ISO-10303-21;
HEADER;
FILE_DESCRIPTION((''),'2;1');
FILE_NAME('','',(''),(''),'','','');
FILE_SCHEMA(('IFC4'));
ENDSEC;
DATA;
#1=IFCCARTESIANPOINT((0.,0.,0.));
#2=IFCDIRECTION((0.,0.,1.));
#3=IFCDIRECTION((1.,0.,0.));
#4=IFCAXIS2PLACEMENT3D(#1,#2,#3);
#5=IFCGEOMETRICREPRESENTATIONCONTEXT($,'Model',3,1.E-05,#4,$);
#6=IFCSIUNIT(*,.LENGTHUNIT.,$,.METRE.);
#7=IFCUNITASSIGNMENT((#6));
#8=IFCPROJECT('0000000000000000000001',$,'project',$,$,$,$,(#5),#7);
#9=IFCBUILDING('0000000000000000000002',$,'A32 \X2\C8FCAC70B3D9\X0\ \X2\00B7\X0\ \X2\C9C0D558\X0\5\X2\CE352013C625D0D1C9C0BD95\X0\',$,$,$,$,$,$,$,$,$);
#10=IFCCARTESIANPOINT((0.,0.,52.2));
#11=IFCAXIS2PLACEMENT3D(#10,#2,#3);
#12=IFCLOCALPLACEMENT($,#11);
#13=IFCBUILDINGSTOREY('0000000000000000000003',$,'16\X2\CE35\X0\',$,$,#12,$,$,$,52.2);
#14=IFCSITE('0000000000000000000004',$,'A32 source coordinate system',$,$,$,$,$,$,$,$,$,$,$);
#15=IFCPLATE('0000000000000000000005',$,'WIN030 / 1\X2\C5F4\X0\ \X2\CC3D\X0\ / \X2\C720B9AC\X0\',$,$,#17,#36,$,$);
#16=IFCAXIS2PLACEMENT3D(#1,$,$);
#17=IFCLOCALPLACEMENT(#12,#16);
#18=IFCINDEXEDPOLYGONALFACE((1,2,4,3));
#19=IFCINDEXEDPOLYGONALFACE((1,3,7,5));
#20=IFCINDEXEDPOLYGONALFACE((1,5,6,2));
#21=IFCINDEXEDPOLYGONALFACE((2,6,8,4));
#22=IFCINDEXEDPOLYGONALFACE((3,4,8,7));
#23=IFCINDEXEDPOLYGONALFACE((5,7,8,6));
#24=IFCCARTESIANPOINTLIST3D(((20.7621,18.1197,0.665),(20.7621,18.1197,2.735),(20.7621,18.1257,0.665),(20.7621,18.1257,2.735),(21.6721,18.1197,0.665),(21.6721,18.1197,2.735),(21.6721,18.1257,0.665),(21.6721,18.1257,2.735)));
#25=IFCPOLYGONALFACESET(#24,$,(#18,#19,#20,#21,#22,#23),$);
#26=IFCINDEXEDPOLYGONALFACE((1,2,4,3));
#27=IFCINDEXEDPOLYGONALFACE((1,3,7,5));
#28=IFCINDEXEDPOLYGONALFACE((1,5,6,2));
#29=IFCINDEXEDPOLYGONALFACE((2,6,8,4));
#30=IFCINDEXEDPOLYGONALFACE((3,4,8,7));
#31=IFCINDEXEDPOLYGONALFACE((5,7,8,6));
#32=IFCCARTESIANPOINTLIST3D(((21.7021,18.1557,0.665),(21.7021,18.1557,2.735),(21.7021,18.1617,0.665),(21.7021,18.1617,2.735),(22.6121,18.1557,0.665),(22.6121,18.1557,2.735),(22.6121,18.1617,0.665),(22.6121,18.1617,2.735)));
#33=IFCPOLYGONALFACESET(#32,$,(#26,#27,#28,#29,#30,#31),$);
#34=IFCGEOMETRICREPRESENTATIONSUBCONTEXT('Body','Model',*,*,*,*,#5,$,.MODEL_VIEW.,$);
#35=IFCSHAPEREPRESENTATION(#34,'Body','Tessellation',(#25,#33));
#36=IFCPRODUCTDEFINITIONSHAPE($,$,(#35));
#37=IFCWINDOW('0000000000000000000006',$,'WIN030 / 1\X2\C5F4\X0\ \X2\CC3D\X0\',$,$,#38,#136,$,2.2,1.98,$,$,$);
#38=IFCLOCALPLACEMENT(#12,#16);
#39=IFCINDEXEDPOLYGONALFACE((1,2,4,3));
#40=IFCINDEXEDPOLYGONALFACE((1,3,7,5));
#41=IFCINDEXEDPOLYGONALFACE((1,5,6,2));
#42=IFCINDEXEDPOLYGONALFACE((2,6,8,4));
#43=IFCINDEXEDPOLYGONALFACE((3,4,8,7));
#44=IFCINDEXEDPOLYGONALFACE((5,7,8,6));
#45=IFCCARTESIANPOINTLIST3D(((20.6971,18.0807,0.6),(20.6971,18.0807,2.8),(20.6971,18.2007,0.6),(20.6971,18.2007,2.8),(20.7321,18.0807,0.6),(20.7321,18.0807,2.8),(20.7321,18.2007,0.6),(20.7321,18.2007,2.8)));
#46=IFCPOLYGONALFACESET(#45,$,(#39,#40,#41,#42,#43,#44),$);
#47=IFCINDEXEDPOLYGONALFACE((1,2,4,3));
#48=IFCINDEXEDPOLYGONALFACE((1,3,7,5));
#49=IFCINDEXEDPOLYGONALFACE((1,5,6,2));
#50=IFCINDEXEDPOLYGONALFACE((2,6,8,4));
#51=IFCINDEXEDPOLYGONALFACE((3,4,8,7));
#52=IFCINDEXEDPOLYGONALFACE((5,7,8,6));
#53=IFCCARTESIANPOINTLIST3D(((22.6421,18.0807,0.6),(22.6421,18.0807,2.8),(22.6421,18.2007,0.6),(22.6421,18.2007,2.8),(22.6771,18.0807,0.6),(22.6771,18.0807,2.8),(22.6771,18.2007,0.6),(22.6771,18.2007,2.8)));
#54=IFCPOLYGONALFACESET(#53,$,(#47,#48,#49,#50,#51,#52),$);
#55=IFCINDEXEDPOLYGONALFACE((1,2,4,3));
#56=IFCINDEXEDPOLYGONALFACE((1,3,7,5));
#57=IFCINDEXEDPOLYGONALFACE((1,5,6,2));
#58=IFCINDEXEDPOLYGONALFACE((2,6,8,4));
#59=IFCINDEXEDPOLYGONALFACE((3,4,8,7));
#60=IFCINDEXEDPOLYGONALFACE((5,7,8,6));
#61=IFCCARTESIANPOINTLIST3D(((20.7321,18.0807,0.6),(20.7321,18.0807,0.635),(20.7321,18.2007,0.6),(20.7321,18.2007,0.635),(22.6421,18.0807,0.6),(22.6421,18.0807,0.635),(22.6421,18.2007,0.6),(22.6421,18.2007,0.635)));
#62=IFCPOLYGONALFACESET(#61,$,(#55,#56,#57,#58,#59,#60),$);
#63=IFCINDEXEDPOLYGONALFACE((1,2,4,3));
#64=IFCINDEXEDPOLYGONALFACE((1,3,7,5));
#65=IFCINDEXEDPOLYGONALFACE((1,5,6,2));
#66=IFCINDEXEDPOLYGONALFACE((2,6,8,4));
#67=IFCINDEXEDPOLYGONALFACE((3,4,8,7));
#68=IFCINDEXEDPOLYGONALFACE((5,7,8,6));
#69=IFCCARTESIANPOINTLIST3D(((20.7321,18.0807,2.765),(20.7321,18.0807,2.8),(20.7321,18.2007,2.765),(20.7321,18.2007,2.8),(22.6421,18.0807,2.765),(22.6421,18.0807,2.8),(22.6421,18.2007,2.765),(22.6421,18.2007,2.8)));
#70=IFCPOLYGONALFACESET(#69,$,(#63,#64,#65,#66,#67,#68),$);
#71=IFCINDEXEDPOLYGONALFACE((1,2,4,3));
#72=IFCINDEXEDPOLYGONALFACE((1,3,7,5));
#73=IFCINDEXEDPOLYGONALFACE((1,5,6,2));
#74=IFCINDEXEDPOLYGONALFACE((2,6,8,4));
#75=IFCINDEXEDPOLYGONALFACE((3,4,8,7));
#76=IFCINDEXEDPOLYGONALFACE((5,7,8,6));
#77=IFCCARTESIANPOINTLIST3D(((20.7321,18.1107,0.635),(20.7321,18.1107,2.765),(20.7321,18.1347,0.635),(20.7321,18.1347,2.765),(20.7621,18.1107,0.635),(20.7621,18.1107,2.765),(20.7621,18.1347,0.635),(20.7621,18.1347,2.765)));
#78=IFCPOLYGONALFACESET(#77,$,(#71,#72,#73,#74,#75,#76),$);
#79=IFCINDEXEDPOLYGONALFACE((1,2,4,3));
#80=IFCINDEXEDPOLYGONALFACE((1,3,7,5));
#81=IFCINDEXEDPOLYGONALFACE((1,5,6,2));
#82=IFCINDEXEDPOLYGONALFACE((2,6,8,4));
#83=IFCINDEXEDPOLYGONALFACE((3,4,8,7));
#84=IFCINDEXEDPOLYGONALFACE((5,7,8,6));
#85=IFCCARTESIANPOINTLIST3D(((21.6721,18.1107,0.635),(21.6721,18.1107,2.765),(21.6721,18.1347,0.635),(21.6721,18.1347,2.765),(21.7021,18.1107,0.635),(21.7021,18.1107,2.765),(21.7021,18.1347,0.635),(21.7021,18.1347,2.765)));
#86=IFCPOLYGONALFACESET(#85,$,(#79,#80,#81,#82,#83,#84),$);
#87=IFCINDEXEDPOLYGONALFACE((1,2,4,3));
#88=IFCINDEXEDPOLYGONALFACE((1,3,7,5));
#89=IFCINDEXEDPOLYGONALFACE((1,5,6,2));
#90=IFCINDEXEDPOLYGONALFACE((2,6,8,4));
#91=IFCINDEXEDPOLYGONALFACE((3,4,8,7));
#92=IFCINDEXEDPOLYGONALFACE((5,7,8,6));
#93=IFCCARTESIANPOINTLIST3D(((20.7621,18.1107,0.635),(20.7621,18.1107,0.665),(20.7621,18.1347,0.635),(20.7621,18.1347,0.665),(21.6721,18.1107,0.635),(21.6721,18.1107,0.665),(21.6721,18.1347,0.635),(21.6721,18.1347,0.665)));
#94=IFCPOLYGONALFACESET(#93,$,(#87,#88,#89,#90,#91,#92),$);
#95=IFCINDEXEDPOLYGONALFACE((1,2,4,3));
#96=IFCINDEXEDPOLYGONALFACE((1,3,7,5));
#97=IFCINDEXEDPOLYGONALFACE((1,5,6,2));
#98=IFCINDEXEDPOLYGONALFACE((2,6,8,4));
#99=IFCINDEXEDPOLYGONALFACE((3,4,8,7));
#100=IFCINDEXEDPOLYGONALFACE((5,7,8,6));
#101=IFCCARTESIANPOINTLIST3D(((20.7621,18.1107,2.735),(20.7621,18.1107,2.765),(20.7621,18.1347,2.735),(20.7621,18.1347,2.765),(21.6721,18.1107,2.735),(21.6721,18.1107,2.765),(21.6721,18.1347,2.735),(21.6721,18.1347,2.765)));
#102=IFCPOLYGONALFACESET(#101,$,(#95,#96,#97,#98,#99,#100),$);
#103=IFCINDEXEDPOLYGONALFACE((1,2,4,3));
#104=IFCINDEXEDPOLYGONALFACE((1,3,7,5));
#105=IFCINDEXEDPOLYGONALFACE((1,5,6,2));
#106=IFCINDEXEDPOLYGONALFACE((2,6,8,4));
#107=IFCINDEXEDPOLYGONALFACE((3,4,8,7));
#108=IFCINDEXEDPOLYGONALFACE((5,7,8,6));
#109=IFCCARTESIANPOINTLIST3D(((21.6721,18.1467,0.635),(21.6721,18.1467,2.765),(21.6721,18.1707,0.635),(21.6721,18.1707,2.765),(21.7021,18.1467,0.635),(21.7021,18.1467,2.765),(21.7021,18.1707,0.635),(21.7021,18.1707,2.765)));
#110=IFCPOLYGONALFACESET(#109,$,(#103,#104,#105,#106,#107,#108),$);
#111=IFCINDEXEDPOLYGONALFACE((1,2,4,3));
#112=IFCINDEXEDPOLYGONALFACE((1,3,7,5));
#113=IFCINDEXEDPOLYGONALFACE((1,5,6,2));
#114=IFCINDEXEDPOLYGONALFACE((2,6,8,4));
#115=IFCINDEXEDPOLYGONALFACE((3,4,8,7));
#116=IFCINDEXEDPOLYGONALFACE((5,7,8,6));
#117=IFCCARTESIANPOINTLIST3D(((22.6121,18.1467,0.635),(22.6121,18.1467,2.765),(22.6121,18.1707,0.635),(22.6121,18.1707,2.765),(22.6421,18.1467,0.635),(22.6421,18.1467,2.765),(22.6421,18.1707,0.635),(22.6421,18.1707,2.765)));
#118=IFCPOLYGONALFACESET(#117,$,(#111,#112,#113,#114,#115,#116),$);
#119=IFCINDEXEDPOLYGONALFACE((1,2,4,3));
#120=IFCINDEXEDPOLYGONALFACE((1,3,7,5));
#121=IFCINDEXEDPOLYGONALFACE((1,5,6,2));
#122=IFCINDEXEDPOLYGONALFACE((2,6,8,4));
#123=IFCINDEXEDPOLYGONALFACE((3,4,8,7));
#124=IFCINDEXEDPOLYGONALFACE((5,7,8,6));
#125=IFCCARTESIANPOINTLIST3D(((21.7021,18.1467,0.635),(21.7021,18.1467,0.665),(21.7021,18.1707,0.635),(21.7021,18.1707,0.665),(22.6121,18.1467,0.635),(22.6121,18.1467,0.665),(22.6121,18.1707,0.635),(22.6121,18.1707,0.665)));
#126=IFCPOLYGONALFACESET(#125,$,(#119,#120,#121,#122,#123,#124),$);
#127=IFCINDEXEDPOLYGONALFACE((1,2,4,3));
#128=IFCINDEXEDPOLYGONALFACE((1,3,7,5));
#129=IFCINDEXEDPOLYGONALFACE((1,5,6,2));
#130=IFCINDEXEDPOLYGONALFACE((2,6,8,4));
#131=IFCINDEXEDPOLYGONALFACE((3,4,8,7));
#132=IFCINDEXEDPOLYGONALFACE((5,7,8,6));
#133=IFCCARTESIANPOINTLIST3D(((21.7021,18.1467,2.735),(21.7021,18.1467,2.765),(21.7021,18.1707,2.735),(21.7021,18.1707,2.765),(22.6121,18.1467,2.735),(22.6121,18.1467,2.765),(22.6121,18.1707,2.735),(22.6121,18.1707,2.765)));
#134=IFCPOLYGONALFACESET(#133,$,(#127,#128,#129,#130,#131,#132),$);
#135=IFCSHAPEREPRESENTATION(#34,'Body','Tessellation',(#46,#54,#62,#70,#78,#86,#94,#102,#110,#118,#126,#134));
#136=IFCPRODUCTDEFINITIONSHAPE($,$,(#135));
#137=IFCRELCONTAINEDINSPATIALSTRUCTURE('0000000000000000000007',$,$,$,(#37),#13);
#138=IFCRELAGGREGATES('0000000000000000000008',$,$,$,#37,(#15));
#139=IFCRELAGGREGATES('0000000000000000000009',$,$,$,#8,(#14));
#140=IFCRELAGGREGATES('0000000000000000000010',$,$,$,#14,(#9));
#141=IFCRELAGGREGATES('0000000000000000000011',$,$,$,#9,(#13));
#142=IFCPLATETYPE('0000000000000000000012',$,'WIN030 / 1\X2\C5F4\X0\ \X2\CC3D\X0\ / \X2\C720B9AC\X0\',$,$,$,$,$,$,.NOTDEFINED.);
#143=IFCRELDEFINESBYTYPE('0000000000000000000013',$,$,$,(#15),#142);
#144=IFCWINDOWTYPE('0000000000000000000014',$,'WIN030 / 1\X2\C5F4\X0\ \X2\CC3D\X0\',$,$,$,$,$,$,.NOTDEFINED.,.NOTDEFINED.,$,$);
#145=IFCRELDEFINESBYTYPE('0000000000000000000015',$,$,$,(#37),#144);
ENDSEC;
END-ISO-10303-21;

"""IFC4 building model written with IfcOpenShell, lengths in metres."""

from ifc_helpers import new_model, si_unit, frame, origin, origin_with_axes, place, context, subcontext, project, spatial, polyline, outline, extrude, source, transform, mapped, type_object, type_shapes, element, aggregate, save


model = new_model("IFC4")

# Units and contexts
model_context = context("Model", 3, precision=1e-05, world=origin_with_axes())
body_context = subcontext(model_context, "Body", "Model", "MODEL_VIEW")
ifc_project = project(units=[si_unit("LENGTHUNIT", "METRE")], contexts=[model_context])

# Plate
storey_placement = place(None, frame((0.0, 0.0, 52.2), z_axis=(0.0, 0.0, 1.0), x_axis=(1.0, 0.0, 0.0)))
plate_type_1 = type_object("IfcPlateType", Name="WIN030 / 1열 창 / 유리", PredefinedType="NOTDEFINED")
shared_shape_1 = source(origin(), body_context, "Body", "SweptSolid", [
    extrude(outline(polyline([(20.7621, 18.1197), (20.7621, 18.1257), (21.6721, 18.1257), (21.6721, 18.1197), (20.7621, 18.1197)])), frame((0.0, 0.0, 0.665)), (0.0, 0.0, 1.0), 2.07),
    extrude(outline(polyline([(21.7021, 18.1557), (21.7021, 18.1617), (22.6121, 18.1617), (22.6121, 18.1557), (21.7021, 18.1557)])), frame((0.0, 0.0, 0.665)), (0.0, 0.0, 1.0), 2.07),
])
type_shapes(plate_type_1, [shared_shape_1])
window_1_placement = place(storey_placement, origin_with_axes())
plate_1_placement = place(window_1_placement, origin_with_axes())
plate_1 = element("IfcPlate", 1, at=plate_1_placement, type_object=plate_type_1, Name="WIN030 / 1열 창 / 유리", context=body_context, shape_type="MappedRepresentation", body=[
    mapped(shared_shape_1, transform((0.0, 0.0, 0.0), scale=1.0)),
])

# Site, building, storey
site = spatial("IfcSite", under=ifc_project, Name="A32 source coordinate system")
building = spatial("IfcBuilding", under=site, Name="A32 주거동 · 지하5층–옥탑지붕")
storey = spatial("IfcBuildingStorey", under=building, at=storey_placement, Name="16층", Elevation=52.2)

# Window
window_type_1 = type_object("IfcWindowType", Name="WIN030 / 1열 창", PartitioningType="NOTDEFINED", PredefinedType="NOTDEFINED")
shared_shape_2 = source(origin(), body_context, "Body", "SweptSolid", [
    extrude(outline(polyline([(20.6971, 18.0807), (20.6971, 18.2007), (20.7321, 18.2007), (20.7321, 18.0807), (20.6971, 18.0807)])), frame((0.0, 0.0, 0.6)), (0.0, 0.0, 1.0), 2.2),
    extrude(outline(polyline([(22.6421, 18.0807), (22.6421, 18.2007), (22.6771, 18.2007), (22.6771, 18.0807), (22.6421, 18.0807)])), frame((0.0, 0.0, 0.6)), (0.0, 0.0, 1.0), 2.2),
    extrude(outline(polyline([(20.7321, 18.0807), (20.7321, 18.2007), (22.6421, 18.2007), (22.6421, 18.0807), (20.7321, 18.0807)])), frame((0.0, 0.0, 0.6)), (0.0, 0.0, 1.0), 0.035),
    extrude(outline(polyline([(20.7321, 18.0807), (20.7321, 18.2007), (22.6421, 18.2007), (22.6421, 18.0807), (20.7321, 18.0807)])), frame((0.0, 0.0, 2.765)), (0.0, 0.0, 1.0), 0.035),
    extrude(outline(polyline([(20.7321, 18.1107), (20.7321, 18.1347), (20.7621, 18.1347), (20.7621, 18.1107), (20.7321, 18.1107)])), frame((0.0, 0.0, 0.635)), (0.0, 0.0, 1.0), 2.13),
    extrude(outline(polyline([(21.6721, 18.1107), (21.6721, 18.1347), (21.7021, 18.1347), (21.7021, 18.1107), (21.6721, 18.1107)])), frame((0.0, 0.0, 0.635)), (0.0, 0.0, 1.0), 2.13),
    extrude(outline(polyline([(20.7621, 18.1107), (20.7621, 18.1347), (21.6721, 18.1347), (21.6721, 18.1107), (20.7621, 18.1107)])), frame((0.0, 0.0, 0.635)), (0.0, 0.0, 1.0), 0.03),
    extrude(outline(polyline([(20.7621, 18.1107), (20.7621, 18.1347), (21.6721, 18.1347), (21.6721, 18.1107), (20.7621, 18.1107)])), frame((0.0, 0.0, 2.735)), (0.0, 0.0, 1.0), 0.03),
    extrude(outline(polyline([(21.6721, 18.1467), (21.6721, 18.1707), (21.7021, 18.1707), (21.7021, 18.1467), (21.6721, 18.1467)])), frame((0.0, 0.0, 0.635)), (0.0, 0.0, 1.0), 2.13),
    extrude(outline(polyline([(22.6121, 18.1467), (22.6121, 18.1707), (22.6421, 18.1707), (22.6421, 18.1467), (22.6121, 18.1467)])), frame((0.0, 0.0, 0.635)), (0.0, 0.0, 1.0), 2.13),
    extrude(outline(polyline([(21.7021, 18.1467), (21.7021, 18.1707), (22.6121, 18.1707), (22.6121, 18.1467), (21.7021, 18.1467)])), frame((0.0, 0.0, 0.635)), (0.0, 0.0, 1.0), 0.03),
    extrude(outline(polyline([(21.7021, 18.1467), (21.7021, 18.1707), (22.6121, 18.1707), (22.6121, 18.1467), (21.7021, 18.1467)])), frame((0.0, 0.0, 2.735)), (0.0, 0.0, 1.0), 0.03),
])
type_shapes(window_type_1, [shared_shape_2])
window_1 = element("IfcWindow", 2, at=window_1_placement, inside=storey, type_object=window_type_1, Name="WIN030 / 1열 창", OverallHeight=2.2, OverallWidth=1.98, context=body_context, shape_type="MappedRepresentation", body=[
    mapped(shared_shape_2, transform((0.0, 0.0, 0.0), scale=1.0)),
])
aggregate(window_1, [plate_1])

save(model, "model.ifc")
